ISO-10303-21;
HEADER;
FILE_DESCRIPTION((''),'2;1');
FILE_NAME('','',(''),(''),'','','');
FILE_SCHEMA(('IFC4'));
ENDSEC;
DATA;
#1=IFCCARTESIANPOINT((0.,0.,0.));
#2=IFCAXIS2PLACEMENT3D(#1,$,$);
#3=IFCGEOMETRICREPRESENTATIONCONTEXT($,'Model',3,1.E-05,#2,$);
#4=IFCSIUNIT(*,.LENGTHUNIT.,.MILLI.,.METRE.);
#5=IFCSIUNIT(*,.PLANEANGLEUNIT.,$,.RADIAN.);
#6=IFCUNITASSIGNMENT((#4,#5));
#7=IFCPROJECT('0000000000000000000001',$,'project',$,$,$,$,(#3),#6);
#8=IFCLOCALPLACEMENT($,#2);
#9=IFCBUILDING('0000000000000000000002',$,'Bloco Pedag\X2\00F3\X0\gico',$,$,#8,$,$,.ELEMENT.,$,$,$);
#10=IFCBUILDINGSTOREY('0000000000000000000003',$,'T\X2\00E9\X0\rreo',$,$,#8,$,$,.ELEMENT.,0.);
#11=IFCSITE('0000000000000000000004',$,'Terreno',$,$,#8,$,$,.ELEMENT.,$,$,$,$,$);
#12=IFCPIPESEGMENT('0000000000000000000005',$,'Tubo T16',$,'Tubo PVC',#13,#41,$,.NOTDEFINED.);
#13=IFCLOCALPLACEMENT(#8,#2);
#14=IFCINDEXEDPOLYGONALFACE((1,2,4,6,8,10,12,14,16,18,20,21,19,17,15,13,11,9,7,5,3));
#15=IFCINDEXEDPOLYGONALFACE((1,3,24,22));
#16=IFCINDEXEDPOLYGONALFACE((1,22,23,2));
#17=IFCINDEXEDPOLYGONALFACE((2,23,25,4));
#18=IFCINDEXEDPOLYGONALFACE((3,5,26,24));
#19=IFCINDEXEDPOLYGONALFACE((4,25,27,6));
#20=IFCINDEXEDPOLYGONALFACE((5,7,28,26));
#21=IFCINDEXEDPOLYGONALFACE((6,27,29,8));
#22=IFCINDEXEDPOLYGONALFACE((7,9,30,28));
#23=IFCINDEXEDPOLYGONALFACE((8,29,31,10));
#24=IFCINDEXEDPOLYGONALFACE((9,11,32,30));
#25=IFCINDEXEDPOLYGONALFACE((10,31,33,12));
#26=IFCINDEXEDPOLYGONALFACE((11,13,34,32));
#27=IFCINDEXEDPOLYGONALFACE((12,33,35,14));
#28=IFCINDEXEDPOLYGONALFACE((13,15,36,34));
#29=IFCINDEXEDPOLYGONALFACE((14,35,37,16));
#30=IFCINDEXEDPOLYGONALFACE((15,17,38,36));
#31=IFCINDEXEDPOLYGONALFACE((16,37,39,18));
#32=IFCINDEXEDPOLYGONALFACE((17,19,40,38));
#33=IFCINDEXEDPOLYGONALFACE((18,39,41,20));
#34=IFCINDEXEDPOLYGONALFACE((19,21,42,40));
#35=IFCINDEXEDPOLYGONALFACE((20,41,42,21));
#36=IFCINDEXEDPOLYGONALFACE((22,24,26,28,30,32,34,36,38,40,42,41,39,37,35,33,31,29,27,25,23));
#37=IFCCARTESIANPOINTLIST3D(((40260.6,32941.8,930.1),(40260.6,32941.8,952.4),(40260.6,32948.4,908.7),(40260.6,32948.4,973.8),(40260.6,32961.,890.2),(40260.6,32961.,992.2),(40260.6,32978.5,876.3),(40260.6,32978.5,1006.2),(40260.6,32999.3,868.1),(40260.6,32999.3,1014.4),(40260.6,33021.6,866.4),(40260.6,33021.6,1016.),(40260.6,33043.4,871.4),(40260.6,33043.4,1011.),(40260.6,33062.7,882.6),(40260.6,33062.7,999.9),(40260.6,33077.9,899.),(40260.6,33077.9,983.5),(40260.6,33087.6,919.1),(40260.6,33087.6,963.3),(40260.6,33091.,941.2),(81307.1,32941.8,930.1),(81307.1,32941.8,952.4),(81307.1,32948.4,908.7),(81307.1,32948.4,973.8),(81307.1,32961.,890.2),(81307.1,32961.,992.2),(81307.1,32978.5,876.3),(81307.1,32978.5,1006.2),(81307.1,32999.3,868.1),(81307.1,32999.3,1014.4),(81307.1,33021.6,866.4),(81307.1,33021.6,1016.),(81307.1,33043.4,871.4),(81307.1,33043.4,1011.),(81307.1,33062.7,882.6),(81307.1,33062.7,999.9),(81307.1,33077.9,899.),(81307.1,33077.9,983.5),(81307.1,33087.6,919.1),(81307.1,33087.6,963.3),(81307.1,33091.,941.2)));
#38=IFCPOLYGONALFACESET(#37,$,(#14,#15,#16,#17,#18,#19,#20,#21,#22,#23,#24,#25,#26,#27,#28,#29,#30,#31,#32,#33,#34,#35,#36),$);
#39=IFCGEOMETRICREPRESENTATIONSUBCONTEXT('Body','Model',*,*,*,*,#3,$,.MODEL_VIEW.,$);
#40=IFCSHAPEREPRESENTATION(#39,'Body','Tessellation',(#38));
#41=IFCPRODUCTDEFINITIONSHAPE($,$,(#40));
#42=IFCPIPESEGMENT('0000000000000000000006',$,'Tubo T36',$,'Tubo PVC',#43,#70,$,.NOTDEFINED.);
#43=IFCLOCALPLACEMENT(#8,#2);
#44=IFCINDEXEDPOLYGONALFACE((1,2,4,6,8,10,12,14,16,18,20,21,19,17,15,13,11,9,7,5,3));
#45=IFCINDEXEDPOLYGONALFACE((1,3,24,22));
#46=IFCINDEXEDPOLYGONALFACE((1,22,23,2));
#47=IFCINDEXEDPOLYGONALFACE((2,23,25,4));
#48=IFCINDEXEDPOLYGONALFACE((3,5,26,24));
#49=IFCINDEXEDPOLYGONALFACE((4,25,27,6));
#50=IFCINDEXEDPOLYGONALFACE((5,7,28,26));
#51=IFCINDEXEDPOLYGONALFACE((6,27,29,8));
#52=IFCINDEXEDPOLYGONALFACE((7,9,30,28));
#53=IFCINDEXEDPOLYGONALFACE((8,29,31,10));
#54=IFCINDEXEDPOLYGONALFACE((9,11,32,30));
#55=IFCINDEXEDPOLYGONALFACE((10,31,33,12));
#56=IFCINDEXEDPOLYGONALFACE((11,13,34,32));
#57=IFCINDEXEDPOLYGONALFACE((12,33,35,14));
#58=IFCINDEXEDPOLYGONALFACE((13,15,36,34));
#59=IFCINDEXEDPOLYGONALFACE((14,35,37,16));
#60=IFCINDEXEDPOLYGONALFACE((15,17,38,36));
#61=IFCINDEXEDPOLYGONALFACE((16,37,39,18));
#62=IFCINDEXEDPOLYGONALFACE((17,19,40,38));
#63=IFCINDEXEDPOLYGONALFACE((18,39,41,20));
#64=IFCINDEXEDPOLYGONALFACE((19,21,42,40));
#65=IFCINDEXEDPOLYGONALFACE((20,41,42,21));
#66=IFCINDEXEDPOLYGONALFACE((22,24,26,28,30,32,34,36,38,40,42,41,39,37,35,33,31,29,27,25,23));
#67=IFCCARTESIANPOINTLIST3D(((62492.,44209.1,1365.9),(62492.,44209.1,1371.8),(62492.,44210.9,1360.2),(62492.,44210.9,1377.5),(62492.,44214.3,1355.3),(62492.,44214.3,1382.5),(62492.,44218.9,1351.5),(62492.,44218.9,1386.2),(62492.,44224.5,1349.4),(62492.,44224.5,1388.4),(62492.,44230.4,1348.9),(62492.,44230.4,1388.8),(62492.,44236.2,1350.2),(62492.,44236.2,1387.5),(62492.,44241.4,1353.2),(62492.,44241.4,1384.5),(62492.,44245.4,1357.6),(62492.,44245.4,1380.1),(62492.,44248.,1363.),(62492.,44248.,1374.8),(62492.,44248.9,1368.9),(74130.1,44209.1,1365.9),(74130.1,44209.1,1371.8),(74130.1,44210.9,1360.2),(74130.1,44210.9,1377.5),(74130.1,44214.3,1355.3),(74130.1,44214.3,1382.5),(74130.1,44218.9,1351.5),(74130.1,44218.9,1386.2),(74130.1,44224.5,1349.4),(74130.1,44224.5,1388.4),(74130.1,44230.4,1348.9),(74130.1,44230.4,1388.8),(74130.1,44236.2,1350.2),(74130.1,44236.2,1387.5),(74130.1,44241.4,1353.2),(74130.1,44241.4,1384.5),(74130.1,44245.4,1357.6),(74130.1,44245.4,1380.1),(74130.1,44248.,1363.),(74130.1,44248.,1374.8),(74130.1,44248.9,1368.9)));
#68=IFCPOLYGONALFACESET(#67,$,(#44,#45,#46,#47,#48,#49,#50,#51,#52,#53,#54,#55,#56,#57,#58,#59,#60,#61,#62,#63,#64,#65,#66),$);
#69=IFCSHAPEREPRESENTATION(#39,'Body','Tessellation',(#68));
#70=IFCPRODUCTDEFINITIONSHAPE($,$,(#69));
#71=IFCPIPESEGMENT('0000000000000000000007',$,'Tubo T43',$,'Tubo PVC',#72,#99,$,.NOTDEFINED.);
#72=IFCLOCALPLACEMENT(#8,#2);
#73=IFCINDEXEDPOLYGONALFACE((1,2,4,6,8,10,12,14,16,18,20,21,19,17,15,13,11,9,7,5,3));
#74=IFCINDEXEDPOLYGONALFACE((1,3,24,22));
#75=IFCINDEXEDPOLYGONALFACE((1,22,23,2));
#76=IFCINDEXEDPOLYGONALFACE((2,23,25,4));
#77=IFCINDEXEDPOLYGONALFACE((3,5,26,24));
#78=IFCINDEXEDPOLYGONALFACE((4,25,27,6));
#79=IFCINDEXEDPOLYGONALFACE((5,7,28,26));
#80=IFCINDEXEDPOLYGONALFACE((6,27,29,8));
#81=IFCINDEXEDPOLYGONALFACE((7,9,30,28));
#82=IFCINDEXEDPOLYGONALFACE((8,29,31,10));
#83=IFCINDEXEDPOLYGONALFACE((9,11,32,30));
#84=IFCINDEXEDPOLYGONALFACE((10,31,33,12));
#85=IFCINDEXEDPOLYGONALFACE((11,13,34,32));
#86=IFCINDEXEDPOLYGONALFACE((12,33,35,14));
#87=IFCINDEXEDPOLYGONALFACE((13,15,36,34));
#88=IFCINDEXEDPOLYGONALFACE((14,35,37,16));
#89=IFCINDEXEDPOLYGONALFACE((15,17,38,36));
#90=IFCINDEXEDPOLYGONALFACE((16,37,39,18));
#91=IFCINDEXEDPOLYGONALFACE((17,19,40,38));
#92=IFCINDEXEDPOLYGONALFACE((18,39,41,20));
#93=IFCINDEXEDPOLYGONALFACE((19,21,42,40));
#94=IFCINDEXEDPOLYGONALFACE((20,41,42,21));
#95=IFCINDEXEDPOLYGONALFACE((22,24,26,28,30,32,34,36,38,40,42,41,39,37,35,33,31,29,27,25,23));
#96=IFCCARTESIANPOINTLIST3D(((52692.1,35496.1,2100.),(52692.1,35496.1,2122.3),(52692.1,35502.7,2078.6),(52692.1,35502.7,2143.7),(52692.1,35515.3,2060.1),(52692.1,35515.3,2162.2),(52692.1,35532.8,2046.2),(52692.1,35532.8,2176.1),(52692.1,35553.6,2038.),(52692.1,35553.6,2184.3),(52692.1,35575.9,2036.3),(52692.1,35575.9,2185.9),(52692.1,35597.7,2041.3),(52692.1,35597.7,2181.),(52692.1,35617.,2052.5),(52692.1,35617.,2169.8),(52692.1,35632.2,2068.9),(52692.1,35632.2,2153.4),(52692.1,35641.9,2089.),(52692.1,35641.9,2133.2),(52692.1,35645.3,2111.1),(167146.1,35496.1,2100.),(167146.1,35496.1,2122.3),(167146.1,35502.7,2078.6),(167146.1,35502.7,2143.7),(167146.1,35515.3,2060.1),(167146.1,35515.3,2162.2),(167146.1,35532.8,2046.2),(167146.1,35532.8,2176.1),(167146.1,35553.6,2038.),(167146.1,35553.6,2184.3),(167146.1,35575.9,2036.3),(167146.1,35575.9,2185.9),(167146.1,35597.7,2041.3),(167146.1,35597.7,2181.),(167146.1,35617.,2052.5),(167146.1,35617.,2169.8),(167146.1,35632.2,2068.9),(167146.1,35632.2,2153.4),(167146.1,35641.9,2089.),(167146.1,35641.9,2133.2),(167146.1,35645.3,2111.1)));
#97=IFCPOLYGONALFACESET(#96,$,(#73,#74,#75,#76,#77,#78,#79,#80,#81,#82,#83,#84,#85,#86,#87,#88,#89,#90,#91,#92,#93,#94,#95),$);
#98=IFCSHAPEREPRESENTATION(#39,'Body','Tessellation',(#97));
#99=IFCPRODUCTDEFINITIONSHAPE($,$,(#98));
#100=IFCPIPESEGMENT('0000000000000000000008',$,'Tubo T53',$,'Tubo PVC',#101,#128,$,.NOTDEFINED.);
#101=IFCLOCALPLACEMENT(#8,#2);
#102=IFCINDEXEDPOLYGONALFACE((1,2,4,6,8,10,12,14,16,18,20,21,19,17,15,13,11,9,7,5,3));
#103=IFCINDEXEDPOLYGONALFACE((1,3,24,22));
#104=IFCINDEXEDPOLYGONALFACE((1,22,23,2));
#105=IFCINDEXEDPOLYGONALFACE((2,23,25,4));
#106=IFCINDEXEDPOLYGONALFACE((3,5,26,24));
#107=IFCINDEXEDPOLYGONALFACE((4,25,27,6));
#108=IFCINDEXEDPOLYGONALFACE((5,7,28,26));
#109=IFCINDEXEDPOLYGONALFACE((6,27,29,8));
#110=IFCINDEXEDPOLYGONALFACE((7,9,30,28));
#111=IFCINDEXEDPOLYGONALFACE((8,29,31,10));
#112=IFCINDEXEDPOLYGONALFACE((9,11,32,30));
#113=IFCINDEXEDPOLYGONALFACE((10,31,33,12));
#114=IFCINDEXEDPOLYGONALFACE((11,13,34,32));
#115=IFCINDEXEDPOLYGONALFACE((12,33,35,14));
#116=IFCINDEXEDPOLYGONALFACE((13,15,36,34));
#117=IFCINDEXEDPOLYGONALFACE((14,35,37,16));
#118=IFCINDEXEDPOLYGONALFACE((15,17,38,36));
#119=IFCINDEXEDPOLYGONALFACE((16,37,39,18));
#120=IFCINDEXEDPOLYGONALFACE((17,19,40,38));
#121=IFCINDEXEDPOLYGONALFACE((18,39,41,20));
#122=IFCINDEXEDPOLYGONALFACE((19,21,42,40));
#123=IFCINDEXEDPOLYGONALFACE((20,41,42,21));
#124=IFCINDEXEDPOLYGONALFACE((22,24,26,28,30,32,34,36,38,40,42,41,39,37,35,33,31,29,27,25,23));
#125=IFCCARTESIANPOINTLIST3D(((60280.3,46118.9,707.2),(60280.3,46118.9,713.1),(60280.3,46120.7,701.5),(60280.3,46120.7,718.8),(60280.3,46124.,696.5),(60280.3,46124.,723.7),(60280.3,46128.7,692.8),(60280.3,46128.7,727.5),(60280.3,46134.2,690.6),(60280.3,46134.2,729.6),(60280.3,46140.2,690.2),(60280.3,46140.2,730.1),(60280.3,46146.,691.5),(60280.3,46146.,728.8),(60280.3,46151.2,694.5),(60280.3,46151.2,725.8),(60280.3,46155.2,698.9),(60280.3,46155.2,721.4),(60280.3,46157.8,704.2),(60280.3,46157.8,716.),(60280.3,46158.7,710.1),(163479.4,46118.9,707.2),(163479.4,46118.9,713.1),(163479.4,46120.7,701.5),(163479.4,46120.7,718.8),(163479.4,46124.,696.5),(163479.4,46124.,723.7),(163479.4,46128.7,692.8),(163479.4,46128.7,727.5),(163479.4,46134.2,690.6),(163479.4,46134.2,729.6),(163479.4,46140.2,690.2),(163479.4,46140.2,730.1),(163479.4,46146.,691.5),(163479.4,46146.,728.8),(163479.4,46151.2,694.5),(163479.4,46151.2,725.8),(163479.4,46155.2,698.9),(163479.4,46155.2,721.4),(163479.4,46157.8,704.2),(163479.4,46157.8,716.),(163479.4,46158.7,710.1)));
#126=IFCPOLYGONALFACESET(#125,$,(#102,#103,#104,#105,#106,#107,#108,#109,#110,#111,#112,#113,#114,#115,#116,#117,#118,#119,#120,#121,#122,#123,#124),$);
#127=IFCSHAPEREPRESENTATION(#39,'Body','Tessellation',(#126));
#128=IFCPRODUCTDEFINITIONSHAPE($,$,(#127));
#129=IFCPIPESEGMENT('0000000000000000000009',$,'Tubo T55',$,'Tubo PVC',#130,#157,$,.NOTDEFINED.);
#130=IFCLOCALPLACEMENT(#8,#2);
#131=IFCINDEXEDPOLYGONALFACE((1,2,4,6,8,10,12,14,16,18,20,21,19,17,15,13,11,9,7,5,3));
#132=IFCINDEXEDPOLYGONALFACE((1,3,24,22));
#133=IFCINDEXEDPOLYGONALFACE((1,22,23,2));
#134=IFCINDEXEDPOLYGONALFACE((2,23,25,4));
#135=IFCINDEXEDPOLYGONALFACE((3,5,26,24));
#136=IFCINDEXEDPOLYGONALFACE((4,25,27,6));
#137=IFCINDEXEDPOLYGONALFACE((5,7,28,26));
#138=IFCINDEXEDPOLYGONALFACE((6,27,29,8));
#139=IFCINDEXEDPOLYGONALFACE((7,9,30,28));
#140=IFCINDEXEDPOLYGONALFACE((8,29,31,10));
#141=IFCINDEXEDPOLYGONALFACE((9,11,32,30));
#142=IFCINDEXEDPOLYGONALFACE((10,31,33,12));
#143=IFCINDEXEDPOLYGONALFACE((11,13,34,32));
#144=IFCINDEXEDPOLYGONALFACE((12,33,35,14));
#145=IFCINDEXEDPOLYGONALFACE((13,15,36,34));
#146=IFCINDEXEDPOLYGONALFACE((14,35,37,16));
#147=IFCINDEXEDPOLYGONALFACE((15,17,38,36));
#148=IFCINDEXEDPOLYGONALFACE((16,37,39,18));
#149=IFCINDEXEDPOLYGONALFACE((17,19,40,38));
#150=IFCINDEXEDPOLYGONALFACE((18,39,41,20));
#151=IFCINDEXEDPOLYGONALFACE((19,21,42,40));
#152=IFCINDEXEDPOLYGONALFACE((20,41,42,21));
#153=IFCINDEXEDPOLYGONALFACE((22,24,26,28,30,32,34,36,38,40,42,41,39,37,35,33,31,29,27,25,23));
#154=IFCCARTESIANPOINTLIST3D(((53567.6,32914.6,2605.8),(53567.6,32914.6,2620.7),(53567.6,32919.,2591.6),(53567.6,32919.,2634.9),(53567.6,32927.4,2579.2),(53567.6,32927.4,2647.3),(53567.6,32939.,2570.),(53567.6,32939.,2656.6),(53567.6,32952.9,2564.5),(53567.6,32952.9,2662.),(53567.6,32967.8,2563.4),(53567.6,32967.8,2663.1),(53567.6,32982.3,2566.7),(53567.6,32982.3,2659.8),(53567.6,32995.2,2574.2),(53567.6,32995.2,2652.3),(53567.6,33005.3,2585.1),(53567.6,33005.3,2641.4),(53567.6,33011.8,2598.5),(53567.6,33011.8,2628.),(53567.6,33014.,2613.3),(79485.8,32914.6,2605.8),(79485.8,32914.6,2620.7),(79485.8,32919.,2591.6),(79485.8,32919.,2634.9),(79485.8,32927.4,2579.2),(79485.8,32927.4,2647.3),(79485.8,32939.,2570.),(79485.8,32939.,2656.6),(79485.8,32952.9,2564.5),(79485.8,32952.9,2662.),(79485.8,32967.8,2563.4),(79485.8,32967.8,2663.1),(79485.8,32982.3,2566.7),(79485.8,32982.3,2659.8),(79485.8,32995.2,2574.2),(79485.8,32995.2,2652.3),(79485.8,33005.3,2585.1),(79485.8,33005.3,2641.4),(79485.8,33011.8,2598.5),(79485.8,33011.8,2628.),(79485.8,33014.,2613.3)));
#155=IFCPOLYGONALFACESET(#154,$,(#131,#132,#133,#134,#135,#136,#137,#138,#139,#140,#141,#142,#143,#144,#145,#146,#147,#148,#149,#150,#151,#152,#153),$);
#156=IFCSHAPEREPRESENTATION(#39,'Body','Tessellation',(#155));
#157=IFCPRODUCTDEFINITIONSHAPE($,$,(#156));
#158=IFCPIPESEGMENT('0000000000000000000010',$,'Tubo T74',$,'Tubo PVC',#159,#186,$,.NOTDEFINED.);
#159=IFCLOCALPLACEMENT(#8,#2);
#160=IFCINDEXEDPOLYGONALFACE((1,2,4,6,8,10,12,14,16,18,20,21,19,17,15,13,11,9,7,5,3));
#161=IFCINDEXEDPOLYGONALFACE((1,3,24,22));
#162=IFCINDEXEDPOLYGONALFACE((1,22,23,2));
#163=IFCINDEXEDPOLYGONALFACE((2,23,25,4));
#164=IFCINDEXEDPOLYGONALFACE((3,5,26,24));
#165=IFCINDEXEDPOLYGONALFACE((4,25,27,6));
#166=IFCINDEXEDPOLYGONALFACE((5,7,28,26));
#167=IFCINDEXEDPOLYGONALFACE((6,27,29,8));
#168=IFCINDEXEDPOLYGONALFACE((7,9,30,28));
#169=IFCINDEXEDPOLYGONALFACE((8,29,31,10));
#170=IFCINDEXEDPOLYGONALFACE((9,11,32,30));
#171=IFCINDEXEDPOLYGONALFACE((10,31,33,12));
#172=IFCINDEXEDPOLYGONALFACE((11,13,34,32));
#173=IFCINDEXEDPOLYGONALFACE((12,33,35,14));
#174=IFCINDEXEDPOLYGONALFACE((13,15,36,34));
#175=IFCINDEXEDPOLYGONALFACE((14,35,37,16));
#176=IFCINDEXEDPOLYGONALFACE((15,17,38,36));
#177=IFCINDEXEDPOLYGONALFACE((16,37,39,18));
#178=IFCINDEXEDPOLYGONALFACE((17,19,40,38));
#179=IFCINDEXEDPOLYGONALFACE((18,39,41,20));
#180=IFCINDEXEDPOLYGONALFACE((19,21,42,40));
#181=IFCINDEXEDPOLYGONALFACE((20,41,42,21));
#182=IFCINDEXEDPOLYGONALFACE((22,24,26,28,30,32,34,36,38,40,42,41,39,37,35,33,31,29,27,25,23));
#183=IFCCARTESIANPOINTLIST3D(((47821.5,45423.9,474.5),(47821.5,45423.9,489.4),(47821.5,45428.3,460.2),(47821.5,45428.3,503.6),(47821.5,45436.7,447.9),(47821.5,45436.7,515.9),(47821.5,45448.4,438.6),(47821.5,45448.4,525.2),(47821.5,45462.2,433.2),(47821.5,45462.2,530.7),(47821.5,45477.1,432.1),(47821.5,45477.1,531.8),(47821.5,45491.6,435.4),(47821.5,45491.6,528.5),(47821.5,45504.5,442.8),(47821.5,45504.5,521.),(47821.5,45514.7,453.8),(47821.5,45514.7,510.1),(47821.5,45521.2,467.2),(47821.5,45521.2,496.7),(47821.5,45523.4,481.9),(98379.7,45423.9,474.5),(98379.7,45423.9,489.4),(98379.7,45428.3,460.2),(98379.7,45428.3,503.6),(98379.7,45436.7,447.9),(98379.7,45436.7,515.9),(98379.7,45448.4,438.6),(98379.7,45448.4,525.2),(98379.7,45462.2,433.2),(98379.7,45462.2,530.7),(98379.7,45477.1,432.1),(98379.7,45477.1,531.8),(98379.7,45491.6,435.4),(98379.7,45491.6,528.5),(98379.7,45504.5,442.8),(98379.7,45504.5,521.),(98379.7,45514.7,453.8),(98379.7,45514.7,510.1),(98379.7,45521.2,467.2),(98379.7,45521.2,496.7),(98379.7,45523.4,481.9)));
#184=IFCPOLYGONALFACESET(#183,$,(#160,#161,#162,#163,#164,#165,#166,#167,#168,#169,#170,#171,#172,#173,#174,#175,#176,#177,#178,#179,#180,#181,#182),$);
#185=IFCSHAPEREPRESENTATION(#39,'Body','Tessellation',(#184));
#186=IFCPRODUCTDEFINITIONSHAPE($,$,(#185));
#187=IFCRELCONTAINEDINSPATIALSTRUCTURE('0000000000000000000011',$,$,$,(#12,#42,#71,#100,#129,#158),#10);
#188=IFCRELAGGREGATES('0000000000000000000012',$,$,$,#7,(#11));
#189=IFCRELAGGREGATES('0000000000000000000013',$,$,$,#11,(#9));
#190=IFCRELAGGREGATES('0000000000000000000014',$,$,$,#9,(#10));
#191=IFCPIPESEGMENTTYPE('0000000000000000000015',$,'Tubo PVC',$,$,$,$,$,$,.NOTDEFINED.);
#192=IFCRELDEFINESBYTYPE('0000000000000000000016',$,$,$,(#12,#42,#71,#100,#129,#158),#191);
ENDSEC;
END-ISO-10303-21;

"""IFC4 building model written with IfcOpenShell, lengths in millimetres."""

from ifc_helpers import new_model, si_unit, frame, origin, origin_2d, place, context, subcontext, project, spatial, circle, extrude, type_object, element, save


model = new_model("IFC4")

# Units and contexts
model_context = context("Model", 3, precision=1e-05, world=origin())
body_context = subcontext(model_context, "Body", "Model", "MODEL_VIEW")
ifc_project = project(units=[si_unit("LENGTHUNIT", "METRE", prefix="MILLI"), si_unit("PLANEANGLEUNIT", "RADIAN")], contexts=[model_context])

# Site, building, storey
placement = place(None, origin())
site = spatial("IfcSite", under=ifc_project, at=placement, Name="Terreno", CompositionType="ELEMENT")
building = spatial("IfcBuilding", under=site, at=placement, Name="Bloco Pedagógico", CompositionType="ELEMENT")
storey = spatial("IfcBuildingStorey", under=building, at=placement, Name="Térreo", CompositionType="ELEMENT", Elevation=0.0)

# Pipe segments
pipe_segment_type = type_object("IfcPipeSegmentType", Name="Tubo PVC", PredefinedType="NOTDEFINED")
pipe_segment_1_placement = place(None, frame((40260.6, 33016.0, 941.2), z_axis=(1.0, 0.0, 0.0), x_axis=(0.0, 1.0, 0.0)))
element("IfcPipeSegment", 1, at=pipe_segment_1_placement, inside=storey, type_object=pipe_segment_type, Name="Tubo T16", ObjectType="Tubo PVC", PredefinedType="NOTDEFINED", context=body_context, shape_type="SweptSolid", body=[
    extrude(circle(Radius=75.0, at=origin_2d()), None, (0.0, 0.0, 1.0), 41046.6),
])
pipe_segment_2_placement = place(None, frame((62492.0, 44228.9, 1368.9), z_axis=(1.0, 0.0, 0.0), x_axis=(0.0, 1.0, 0.0)))
element("IfcPipeSegment", 2, at=pipe_segment_2_placement, inside=storey, type_object=pipe_segment_type, Name="Tubo T36", ObjectType="Tubo PVC", PredefinedType="NOTDEFINED", context=body_context, shape_type="SweptSolid", body=[
    extrude(circle(Radius=20.0, at=origin_2d()), None, (0.0, 0.0, 1.0), 11638.1),
])
pipe_segment_3_placement = place(None, frame((52692.1, 35570.3, 2111.1), z_axis=(1.0, 0.0, 0.0), x_axis=(0.0, 1.0, 0.0)))
element("IfcPipeSegment", 3, at=pipe_segment_3_placement, inside=storey, type_object=pipe_segment_type, Name="Tubo T43", ObjectType="Tubo PVC", PredefinedType="NOTDEFINED", context=body_context, shape_type="SweptSolid", body=[
    extrude(circle(Radius=75.0, at=origin_2d()), None, (0.0, 0.0, 1.0), 114454.0),
])
pipe_segment_4_placement = place(None, frame((60280.3, 46138.7, 710.1), z_axis=(1.0, 0.0, 0.0), x_axis=(0.0, 1.0, 0.0)))
element("IfcPipeSegment", 4, at=pipe_segment_4_placement, inside=storey, type_object=pipe_segment_type, Name="Tubo T53", ObjectType="Tubo PVC", PredefinedType="NOTDEFINED", context=body_context, shape_type="SweptSolid", body=[
    extrude(circle(Radius=20.0, at=origin_2d()), None, (0.0, 0.0, 1.0), 103199.1),
])
pipe_segment_5_placement = place(None, frame((53567.6, 32964.0, 2613.3), z_axis=(1.0, 0.0, 0.0), x_axis=(0.0, 1.0, 0.0)))
element("IfcPipeSegment", 5, at=pipe_segment_5_placement, inside=storey, type_object=pipe_segment_type, Name="Tubo T55", ObjectType="Tubo PVC", PredefinedType="NOTDEFINED", context=body_context, shape_type="SweptSolid", body=[
    extrude(circle(Radius=50.0, at=origin_2d()), None, (0.0, 0.0, 1.0), 25918.2),
])
pipe_segment_6_placement = place(None, frame((47821.5, 45473.4, 481.9), z_axis=(1.0, 0.0, 0.0), x_axis=(0.0, 1.0, 0.0)))
element("IfcPipeSegment", 6, at=pipe_segment_6_placement, inside=storey, type_object=pipe_segment_type, Name="Tubo T74", ObjectType="Tubo PVC", PredefinedType="NOTDEFINED", context=body_context, shape_type="SweptSolid", body=[
    extrude(circle(Radius=50.0, at=origin_2d()), None, (0.0, 0.0, 1.0), 50558.2),
])

save(model, "model.ifc")
